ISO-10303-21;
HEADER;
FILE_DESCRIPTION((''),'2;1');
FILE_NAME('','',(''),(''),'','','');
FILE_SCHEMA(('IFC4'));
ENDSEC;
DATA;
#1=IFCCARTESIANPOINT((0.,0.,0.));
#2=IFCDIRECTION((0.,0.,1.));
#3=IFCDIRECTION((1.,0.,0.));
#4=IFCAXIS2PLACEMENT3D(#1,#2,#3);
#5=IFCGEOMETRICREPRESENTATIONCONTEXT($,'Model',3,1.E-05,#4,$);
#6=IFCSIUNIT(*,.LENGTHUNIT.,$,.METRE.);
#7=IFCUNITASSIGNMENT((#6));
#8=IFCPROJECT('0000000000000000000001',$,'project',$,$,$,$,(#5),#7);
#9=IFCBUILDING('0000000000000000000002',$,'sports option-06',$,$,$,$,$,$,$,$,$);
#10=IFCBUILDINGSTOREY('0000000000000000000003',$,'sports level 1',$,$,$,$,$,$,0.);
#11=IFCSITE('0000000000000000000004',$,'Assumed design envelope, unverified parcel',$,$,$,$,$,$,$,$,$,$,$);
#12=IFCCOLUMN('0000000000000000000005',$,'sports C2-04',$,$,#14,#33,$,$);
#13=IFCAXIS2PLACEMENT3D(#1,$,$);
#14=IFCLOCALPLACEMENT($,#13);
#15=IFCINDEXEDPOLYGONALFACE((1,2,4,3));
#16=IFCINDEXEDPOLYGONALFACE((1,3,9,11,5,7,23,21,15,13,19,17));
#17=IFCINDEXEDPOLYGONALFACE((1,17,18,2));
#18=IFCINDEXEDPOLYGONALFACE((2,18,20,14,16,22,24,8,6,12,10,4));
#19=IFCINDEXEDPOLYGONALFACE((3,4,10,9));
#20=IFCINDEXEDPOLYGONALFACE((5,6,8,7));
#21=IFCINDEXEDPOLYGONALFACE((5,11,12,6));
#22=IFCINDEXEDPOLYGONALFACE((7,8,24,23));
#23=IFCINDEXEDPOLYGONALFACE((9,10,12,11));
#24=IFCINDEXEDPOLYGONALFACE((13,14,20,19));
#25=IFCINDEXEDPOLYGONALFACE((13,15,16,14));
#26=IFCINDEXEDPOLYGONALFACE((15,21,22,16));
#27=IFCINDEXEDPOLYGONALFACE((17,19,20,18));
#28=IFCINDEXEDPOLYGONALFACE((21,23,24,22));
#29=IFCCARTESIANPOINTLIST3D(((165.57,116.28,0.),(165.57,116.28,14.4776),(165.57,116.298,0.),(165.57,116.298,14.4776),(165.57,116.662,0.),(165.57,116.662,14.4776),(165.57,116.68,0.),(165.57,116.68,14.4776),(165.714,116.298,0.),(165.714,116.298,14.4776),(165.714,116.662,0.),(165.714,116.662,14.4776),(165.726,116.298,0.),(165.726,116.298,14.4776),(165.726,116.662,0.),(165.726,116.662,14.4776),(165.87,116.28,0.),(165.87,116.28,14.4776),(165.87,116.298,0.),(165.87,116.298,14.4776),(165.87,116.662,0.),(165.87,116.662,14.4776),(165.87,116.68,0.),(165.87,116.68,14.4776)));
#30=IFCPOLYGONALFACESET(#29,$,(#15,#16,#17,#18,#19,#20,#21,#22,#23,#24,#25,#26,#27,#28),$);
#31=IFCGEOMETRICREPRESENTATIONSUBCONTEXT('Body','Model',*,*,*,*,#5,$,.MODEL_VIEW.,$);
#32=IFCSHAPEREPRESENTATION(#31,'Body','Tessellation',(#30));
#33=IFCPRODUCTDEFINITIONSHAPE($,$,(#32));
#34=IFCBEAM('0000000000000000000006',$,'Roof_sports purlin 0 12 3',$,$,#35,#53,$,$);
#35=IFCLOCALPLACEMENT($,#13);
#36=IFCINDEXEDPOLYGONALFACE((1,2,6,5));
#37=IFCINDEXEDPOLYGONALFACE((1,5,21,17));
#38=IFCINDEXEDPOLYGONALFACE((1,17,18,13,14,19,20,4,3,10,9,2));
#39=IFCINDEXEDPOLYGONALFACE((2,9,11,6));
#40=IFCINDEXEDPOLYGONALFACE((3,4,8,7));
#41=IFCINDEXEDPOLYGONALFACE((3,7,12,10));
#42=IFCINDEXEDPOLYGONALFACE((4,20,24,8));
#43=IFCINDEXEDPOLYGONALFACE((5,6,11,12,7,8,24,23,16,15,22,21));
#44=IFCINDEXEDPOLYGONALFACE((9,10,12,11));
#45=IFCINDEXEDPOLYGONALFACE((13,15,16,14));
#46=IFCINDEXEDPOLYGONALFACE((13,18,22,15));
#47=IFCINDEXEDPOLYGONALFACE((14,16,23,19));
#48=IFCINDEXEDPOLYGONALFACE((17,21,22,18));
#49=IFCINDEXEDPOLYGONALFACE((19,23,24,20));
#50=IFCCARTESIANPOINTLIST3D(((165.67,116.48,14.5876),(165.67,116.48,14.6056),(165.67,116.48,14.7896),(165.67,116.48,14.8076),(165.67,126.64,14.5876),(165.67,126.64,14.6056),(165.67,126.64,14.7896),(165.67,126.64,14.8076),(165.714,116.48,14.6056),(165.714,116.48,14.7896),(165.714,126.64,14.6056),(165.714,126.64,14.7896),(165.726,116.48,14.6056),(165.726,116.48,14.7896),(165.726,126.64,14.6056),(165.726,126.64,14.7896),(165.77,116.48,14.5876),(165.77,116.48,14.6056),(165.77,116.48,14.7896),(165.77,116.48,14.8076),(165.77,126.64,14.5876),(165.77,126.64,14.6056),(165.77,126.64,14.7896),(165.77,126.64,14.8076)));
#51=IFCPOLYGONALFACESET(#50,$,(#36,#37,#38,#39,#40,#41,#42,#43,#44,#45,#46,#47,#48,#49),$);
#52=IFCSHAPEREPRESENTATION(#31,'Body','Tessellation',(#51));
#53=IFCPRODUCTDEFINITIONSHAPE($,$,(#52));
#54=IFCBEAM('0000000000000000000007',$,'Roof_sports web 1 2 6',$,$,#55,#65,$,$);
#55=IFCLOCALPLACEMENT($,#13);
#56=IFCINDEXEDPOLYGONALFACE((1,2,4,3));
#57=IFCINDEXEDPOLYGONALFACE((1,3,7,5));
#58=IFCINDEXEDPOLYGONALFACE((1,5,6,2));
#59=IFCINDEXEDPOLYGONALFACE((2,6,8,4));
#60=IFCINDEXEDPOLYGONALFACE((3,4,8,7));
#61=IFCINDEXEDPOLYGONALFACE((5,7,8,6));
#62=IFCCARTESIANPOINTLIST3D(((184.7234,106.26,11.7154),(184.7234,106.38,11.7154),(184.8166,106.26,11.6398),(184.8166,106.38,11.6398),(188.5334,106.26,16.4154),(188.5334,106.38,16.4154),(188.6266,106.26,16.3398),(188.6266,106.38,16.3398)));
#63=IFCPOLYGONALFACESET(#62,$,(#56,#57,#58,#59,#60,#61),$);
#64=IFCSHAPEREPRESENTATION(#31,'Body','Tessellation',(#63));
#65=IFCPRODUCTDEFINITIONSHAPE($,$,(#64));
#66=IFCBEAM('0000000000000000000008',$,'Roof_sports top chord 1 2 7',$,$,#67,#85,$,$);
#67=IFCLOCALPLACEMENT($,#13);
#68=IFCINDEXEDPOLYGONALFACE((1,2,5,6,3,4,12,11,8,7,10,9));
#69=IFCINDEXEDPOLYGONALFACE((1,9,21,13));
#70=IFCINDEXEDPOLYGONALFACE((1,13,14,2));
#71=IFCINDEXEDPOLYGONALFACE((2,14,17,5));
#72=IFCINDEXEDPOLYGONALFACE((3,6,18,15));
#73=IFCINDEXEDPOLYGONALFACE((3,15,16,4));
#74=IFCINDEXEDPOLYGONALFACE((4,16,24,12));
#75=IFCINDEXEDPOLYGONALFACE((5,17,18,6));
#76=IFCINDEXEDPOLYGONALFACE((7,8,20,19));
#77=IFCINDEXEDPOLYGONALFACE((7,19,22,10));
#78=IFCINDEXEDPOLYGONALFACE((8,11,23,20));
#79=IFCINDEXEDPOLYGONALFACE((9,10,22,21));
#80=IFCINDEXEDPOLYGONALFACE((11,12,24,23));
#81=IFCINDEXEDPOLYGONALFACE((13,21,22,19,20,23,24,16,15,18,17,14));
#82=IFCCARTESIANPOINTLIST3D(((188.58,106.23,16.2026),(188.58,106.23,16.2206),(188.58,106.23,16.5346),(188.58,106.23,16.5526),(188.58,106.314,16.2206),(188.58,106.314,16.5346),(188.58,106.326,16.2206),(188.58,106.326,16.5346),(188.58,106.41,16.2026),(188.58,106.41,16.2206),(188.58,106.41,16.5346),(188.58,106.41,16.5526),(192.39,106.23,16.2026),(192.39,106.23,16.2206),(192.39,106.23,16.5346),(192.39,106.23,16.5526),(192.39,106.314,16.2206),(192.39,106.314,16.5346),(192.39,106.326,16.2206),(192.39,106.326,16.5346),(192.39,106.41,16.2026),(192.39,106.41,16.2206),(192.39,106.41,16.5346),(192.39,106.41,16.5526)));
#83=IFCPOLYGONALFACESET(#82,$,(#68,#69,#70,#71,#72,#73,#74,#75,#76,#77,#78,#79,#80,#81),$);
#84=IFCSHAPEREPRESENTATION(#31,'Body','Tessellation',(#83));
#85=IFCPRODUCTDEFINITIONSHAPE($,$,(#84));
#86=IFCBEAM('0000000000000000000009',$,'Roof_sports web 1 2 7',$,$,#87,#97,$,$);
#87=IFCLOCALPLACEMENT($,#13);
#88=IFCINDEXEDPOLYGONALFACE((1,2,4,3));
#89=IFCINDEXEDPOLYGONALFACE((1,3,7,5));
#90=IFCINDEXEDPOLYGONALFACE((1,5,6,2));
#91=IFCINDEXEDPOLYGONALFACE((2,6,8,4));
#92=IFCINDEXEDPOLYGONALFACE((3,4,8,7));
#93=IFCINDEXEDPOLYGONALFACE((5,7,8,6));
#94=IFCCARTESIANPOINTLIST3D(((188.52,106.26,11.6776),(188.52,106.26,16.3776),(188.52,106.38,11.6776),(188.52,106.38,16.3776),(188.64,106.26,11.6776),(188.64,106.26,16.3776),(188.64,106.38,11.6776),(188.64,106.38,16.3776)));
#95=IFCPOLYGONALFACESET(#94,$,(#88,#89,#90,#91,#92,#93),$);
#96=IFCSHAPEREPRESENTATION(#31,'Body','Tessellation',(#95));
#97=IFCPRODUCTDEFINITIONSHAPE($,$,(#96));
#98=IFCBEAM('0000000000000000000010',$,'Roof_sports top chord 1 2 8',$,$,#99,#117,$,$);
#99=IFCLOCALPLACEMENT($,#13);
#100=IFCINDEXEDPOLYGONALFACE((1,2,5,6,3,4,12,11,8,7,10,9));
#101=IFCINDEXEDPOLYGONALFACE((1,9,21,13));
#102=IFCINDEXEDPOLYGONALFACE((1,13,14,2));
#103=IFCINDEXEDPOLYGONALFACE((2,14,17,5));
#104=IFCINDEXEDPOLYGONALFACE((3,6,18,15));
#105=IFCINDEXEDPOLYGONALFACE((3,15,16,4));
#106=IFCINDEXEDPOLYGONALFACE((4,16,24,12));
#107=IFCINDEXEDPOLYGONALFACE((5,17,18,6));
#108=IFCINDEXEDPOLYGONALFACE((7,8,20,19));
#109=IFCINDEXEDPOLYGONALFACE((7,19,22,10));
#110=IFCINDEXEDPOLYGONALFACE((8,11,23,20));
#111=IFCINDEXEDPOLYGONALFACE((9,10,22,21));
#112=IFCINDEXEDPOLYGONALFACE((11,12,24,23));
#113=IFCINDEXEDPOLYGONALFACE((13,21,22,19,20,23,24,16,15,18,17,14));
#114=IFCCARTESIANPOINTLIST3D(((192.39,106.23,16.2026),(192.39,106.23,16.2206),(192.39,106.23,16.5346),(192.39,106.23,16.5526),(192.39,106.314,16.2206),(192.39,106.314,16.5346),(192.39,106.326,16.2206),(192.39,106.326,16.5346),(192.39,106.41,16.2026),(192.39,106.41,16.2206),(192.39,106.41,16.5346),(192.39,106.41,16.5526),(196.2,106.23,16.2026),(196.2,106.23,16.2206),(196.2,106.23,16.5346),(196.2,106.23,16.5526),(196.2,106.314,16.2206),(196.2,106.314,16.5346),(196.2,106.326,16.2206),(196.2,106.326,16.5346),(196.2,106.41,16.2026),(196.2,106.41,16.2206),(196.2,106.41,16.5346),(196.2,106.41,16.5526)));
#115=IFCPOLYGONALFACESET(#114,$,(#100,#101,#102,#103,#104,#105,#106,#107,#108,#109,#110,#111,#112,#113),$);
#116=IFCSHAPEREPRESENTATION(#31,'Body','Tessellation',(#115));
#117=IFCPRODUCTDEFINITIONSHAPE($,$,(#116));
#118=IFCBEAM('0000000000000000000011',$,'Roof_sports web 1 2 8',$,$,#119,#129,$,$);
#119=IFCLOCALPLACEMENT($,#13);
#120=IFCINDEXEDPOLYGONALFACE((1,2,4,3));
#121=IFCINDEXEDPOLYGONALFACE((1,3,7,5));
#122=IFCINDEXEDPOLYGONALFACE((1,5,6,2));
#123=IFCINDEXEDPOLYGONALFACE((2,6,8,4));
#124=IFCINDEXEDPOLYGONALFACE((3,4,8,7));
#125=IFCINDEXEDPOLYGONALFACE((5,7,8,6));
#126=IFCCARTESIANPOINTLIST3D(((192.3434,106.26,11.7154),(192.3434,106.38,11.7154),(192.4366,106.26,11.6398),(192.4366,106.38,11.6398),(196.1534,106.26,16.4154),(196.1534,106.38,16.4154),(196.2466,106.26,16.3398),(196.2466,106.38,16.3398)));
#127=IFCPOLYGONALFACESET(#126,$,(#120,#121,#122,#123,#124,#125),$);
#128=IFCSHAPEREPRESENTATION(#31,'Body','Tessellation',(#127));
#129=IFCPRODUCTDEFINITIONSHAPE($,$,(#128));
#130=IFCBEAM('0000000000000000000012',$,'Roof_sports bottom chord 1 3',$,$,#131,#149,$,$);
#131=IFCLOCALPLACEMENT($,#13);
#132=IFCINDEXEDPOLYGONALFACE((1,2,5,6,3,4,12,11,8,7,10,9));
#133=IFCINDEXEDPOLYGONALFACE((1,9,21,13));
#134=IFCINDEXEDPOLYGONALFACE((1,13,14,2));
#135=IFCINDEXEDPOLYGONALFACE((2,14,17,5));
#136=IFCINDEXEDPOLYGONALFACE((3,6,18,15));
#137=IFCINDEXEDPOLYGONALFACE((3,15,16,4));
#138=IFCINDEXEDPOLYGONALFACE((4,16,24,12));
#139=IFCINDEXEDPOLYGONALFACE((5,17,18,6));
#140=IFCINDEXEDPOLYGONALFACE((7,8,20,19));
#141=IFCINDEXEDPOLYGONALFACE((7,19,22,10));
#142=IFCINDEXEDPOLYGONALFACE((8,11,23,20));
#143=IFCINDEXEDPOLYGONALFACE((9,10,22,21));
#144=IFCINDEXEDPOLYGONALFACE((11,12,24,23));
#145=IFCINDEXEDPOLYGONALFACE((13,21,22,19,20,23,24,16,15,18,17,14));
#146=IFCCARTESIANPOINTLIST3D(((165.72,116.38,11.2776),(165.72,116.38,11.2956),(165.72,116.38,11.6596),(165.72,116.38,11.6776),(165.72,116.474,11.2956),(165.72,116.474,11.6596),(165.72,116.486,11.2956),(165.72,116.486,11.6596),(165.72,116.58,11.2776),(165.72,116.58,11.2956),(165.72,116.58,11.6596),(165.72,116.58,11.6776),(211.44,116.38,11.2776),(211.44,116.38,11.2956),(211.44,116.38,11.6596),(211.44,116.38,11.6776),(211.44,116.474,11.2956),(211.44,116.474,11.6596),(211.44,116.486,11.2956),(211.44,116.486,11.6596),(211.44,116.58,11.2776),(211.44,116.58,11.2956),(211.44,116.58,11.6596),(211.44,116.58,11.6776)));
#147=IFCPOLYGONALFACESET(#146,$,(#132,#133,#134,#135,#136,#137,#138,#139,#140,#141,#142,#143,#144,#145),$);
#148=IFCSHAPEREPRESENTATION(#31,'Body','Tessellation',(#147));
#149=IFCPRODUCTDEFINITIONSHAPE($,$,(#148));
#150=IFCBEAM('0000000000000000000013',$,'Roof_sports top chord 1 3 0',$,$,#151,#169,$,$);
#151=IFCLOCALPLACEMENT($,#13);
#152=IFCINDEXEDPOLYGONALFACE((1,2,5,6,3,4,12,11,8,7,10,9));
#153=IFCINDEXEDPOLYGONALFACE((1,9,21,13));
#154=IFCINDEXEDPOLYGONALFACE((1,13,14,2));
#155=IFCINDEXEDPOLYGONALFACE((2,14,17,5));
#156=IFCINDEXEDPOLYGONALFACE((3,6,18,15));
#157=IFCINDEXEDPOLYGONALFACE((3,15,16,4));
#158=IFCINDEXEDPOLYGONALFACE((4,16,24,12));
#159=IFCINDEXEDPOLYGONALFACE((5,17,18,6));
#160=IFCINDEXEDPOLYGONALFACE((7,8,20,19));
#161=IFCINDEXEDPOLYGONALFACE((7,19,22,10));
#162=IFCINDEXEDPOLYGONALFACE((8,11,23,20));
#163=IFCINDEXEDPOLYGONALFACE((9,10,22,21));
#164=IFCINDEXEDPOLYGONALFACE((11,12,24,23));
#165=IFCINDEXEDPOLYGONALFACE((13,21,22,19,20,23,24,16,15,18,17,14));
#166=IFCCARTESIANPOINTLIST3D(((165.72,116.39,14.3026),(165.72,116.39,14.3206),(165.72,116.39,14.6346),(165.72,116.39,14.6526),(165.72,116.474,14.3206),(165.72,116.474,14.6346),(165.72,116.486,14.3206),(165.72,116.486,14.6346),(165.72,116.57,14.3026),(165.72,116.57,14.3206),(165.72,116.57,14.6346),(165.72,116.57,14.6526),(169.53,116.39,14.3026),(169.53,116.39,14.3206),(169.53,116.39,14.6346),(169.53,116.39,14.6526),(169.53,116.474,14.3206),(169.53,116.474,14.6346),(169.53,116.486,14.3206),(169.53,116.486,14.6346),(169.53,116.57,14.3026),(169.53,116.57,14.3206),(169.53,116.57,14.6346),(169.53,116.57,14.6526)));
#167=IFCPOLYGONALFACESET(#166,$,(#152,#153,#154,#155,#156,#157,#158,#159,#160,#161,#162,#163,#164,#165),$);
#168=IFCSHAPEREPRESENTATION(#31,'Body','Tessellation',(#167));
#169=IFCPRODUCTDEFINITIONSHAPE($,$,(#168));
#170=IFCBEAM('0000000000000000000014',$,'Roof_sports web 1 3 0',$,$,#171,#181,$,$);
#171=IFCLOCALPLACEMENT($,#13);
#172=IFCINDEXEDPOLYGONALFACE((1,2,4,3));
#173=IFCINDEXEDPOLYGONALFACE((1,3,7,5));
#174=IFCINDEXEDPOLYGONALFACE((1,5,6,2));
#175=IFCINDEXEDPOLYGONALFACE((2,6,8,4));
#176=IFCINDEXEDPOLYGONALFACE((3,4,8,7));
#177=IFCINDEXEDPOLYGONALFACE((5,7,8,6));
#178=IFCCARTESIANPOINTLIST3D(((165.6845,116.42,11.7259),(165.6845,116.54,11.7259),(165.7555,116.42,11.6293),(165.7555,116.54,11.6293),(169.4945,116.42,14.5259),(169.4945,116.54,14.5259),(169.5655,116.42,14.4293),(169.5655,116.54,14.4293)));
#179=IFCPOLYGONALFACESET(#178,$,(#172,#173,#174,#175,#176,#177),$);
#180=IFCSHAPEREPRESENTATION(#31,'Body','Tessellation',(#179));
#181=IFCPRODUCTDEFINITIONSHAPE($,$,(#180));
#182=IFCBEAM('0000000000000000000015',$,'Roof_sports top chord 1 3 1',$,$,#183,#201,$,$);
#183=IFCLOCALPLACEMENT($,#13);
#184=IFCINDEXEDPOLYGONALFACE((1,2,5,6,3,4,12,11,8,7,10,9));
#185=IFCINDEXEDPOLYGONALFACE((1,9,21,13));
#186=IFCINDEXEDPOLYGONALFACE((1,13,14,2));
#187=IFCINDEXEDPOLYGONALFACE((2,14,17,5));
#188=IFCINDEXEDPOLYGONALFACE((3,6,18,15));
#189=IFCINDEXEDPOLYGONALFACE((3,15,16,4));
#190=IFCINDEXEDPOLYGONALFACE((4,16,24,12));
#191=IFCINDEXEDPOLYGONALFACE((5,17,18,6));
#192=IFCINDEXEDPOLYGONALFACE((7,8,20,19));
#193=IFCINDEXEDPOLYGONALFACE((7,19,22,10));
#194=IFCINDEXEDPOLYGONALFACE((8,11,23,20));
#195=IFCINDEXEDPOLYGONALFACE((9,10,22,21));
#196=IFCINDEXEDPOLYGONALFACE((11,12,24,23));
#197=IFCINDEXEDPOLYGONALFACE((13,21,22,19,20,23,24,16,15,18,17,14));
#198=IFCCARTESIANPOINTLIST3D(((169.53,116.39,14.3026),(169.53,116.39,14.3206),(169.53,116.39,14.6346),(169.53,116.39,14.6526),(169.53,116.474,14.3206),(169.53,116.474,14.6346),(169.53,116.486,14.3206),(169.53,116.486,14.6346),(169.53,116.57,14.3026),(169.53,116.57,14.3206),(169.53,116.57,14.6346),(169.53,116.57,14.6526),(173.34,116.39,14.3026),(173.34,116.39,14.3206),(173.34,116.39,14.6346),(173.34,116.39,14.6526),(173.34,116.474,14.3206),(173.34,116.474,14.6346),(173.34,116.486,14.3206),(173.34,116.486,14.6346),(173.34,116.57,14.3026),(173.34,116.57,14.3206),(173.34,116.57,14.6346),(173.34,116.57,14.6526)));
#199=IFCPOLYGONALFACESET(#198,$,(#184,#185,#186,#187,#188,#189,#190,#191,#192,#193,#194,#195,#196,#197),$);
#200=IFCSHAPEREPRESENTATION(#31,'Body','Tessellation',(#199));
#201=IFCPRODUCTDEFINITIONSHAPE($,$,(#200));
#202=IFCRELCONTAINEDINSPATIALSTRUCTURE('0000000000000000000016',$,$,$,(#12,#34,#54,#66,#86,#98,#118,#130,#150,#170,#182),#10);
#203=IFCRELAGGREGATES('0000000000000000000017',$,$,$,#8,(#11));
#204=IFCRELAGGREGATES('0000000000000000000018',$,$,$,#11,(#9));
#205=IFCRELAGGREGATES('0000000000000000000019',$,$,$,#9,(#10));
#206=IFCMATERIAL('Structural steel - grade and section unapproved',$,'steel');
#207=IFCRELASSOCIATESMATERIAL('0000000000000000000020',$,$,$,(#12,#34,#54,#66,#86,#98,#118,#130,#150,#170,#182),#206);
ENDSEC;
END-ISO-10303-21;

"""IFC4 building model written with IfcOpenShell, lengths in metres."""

from ifc_helpers import new_model, si_unit, frame, origin_with_axes, place, context, subcontext, project, spatial, rectangle, i_section, extrude, material, element, save


model = new_model("IFC4")

# Units and contexts
model_context = context("Model", 3, precision=1e-05, world=origin_with_axes())
body_context = subcontext(model_context, "Body", "Model", "MODEL_VIEW")
ifc_project = project(units=[si_unit("LENGTHUNIT", "METRE")], contexts=[model_context])

# Site, building, storey
site = spatial("IfcSite", under=ifc_project, Name="Assumed design envelope, unverified parcel")
building = spatial("IfcBuilding", under=site, Name="sports option-06")
storey = spatial("IfcBuildingStorey", under=building, Name="sports level 1", Elevation=0.0)

# Column
ifc_material = material(Name="Structural steel - grade and section unapproved", Category="steel")
column_placement = place(None, frame((165.72, 116.48, 0.0), z_axis=(0.0, 0.0, 1.0), x_axis=(-1.0, 0.0, 0.0)))
element("IfcColumn", 1, at=column_placement, inside=storey, material=ifc_material, Name="sports C2-04", context=body_context, shape_type="SweptSolid", body=[
    extrude(i_section(OverallWidth=0.3, OverallDepth=0.4, WebThickness=0.012, FlangeThickness=0.018, FilletRadius=0.0), origin_with_axes(), (0.0, 0.0, 1.0), 14.4776),
])

# Beams
beam_1_placement = place(None, frame((165.72, 116.48, 14.6976), z_axis=(0.0, 1.0, 0.0), x_axis=(-1.0, 0.0, 0.0)))
element("IfcBeam", 2, at=beam_1_placement, inside=storey, material=ifc_material, Name="Roof_sports purlin 0 12 3", context=body_context, shape_type="SweptSolid", body=[
    extrude(i_section(OverallWidth=0.1, OverallDepth=0.22, WebThickness=0.012, FlangeThickness=0.018, FilletRadius=0.0), origin_with_axes(), (0.0, 0.0, 1.0), 10.16),
])
beam_2_placement = place(None, frame((184.77, 106.32, 11.6776), z_axis=(0.629721, 0.0, 0.776821), x_axis=(0.0, 1.0, 0.0)))
element("IfcBeam", 3, at=beam_2_placement, inside=storey, material=ifc_material, Name="Roof_sports web 1 2 6", context=body_context, shape_type="SweptSolid", body=[
    extrude(rectangle(XDim=0.12, YDim=0.12), origin_with_axes(), (0.0, 0.0, 1.0), 6.0503),
])
beam_3_placement = place(None, frame((188.58, 106.32, 16.3776), z_axis=(1.0, 0.0, 0.0), x_axis=(0.0, 1.0, 0.0)))
element("IfcBeam", 4, at=beam_3_placement, inside=storey, material=ifc_material, Name="Roof_sports top chord 1 2 7", context=body_context, shape_type="SweptSolid", body=[
    extrude(i_section(OverallWidth=0.18, OverallDepth=0.35, WebThickness=0.012, FlangeThickness=0.018, FilletRadius=0.0), origin_with_axes(), (0.0, 0.0, 1.0), 3.81),
])
beam_4_placement = place(None, frame((188.58, 106.32, 11.6776), z_axis=(0.0, 0.0, 1.0), x_axis=(-1.0, 0.0, 0.0)))
element("IfcBeam", 5, at=beam_4_placement, inside=storey, material=ifc_material, Name="Roof_sports web 1 2 7", context=body_context, shape_type="SweptSolid", body=[
    extrude(rectangle(XDim=0.12, YDim=0.12), origin_with_axes(), (0.0, 0.0, 1.0), 4.7),
])
beam_5_placement = place(None, frame((192.39, 106.32, 16.3776), z_axis=(1.0, 0.0, 0.0), x_axis=(0.0, 1.0, 0.0)))
element("IfcBeam", 6, at=beam_5_placement, inside=storey, material=ifc_material, Name="Roof_sports top chord 1 2 8", context=body_context, shape_type="SweptSolid", body=[
    extrude(i_section(OverallWidth=0.18, OverallDepth=0.35, WebThickness=0.012, FlangeThickness=0.018, FilletRadius=0.0), origin_with_axes(), (0.0, 0.0, 1.0), 3.81),
])
beam_6_placement = place(None, frame((192.39, 106.32, 11.6776), z_axis=(0.629721, 0.0, 0.776821), x_axis=(0.0, 1.0, 0.0)))
element("IfcBeam", 7, at=beam_6_placement, inside=storey, material=ifc_material, Name="Roof_sports web 1 2 8", context=body_context, shape_type="SweptSolid", body=[
    extrude(rectangle(XDim=0.12, YDim=0.12), origin_with_axes(), (0.0, 0.0, 1.0), 6.0503),
])
beam_7_placement = place(None, frame((165.72, 116.48, 11.4776), z_axis=(1.0, 0.0, 0.0), x_axis=(0.0, 1.0, 0.0)))
element("IfcBeam", 8, at=beam_7_placement, inside=storey, material=ifc_material, Name="Roof_sports bottom chord 1 3", context=body_context, shape_type="SweptSolid", body=[
    extrude(i_section(OverallWidth=0.2, OverallDepth=0.4, WebThickness=0.012, FlangeThickness=0.018, FilletRadius=0.0), origin_with_axes(), (0.0, 0.0, 1.0), 45.72),
])
beam_8_placement = place(None, frame((165.72, 116.48, 14.4776), z_axis=(1.0, 0.0, 0.0), x_axis=(0.0, 1.0, 0.0)))
element("IfcBeam", 9, at=beam_8_placement, inside=storey, material=ifc_material, Name="Roof_sports top chord 1 3 0", context=body_context, shape_type="SweptSolid", body=[
    extrude(i_section(OverallWidth=0.18, OverallDepth=0.35, WebThickness=0.012, FlangeThickness=0.018, FilletRadius=0.0), origin_with_axes(), (0.0, 0.0, 1.0), 3.81),
])
beam_9_placement = place(None, frame((165.72, 116.48, 11.6776), z_axis=(0.805799, 0.0, 0.592189), x_axis=(0.0, 1.0, 0.0)))
element("IfcBeam", 10, at=beam_9_placement, inside=storey, material=ifc_material, Name="Roof_sports web 1 3 0", context=body_context, shape_type="SweptSolid", body=[
    extrude(rectangle(XDim=0.12, YDim=0.12), origin_with_axes(), (0.0, 0.0, 1.0), 4.7282),
])
beam_10_placement = place(None, frame((169.53, 116.48, 14.4776), z_axis=(1.0, 0.0, 0.0), x_axis=(0.0, 1.0, 0.0)))
element("IfcBeam", 11, at=beam_10_placement, inside=storey, material=ifc_material, Name="Roof_sports top chord 1 3 1", context=body_context, shape_type="SweptSolid", body=[
    extrude(i_section(OverallWidth=0.18, OverallDepth=0.35, WebThickness=0.012, FlangeThickness=0.018, FilletRadius=0.0), origin_with_axes(), (0.0, 0.0, 1.0), 3.81),
])

save(model, "model.ifc")
